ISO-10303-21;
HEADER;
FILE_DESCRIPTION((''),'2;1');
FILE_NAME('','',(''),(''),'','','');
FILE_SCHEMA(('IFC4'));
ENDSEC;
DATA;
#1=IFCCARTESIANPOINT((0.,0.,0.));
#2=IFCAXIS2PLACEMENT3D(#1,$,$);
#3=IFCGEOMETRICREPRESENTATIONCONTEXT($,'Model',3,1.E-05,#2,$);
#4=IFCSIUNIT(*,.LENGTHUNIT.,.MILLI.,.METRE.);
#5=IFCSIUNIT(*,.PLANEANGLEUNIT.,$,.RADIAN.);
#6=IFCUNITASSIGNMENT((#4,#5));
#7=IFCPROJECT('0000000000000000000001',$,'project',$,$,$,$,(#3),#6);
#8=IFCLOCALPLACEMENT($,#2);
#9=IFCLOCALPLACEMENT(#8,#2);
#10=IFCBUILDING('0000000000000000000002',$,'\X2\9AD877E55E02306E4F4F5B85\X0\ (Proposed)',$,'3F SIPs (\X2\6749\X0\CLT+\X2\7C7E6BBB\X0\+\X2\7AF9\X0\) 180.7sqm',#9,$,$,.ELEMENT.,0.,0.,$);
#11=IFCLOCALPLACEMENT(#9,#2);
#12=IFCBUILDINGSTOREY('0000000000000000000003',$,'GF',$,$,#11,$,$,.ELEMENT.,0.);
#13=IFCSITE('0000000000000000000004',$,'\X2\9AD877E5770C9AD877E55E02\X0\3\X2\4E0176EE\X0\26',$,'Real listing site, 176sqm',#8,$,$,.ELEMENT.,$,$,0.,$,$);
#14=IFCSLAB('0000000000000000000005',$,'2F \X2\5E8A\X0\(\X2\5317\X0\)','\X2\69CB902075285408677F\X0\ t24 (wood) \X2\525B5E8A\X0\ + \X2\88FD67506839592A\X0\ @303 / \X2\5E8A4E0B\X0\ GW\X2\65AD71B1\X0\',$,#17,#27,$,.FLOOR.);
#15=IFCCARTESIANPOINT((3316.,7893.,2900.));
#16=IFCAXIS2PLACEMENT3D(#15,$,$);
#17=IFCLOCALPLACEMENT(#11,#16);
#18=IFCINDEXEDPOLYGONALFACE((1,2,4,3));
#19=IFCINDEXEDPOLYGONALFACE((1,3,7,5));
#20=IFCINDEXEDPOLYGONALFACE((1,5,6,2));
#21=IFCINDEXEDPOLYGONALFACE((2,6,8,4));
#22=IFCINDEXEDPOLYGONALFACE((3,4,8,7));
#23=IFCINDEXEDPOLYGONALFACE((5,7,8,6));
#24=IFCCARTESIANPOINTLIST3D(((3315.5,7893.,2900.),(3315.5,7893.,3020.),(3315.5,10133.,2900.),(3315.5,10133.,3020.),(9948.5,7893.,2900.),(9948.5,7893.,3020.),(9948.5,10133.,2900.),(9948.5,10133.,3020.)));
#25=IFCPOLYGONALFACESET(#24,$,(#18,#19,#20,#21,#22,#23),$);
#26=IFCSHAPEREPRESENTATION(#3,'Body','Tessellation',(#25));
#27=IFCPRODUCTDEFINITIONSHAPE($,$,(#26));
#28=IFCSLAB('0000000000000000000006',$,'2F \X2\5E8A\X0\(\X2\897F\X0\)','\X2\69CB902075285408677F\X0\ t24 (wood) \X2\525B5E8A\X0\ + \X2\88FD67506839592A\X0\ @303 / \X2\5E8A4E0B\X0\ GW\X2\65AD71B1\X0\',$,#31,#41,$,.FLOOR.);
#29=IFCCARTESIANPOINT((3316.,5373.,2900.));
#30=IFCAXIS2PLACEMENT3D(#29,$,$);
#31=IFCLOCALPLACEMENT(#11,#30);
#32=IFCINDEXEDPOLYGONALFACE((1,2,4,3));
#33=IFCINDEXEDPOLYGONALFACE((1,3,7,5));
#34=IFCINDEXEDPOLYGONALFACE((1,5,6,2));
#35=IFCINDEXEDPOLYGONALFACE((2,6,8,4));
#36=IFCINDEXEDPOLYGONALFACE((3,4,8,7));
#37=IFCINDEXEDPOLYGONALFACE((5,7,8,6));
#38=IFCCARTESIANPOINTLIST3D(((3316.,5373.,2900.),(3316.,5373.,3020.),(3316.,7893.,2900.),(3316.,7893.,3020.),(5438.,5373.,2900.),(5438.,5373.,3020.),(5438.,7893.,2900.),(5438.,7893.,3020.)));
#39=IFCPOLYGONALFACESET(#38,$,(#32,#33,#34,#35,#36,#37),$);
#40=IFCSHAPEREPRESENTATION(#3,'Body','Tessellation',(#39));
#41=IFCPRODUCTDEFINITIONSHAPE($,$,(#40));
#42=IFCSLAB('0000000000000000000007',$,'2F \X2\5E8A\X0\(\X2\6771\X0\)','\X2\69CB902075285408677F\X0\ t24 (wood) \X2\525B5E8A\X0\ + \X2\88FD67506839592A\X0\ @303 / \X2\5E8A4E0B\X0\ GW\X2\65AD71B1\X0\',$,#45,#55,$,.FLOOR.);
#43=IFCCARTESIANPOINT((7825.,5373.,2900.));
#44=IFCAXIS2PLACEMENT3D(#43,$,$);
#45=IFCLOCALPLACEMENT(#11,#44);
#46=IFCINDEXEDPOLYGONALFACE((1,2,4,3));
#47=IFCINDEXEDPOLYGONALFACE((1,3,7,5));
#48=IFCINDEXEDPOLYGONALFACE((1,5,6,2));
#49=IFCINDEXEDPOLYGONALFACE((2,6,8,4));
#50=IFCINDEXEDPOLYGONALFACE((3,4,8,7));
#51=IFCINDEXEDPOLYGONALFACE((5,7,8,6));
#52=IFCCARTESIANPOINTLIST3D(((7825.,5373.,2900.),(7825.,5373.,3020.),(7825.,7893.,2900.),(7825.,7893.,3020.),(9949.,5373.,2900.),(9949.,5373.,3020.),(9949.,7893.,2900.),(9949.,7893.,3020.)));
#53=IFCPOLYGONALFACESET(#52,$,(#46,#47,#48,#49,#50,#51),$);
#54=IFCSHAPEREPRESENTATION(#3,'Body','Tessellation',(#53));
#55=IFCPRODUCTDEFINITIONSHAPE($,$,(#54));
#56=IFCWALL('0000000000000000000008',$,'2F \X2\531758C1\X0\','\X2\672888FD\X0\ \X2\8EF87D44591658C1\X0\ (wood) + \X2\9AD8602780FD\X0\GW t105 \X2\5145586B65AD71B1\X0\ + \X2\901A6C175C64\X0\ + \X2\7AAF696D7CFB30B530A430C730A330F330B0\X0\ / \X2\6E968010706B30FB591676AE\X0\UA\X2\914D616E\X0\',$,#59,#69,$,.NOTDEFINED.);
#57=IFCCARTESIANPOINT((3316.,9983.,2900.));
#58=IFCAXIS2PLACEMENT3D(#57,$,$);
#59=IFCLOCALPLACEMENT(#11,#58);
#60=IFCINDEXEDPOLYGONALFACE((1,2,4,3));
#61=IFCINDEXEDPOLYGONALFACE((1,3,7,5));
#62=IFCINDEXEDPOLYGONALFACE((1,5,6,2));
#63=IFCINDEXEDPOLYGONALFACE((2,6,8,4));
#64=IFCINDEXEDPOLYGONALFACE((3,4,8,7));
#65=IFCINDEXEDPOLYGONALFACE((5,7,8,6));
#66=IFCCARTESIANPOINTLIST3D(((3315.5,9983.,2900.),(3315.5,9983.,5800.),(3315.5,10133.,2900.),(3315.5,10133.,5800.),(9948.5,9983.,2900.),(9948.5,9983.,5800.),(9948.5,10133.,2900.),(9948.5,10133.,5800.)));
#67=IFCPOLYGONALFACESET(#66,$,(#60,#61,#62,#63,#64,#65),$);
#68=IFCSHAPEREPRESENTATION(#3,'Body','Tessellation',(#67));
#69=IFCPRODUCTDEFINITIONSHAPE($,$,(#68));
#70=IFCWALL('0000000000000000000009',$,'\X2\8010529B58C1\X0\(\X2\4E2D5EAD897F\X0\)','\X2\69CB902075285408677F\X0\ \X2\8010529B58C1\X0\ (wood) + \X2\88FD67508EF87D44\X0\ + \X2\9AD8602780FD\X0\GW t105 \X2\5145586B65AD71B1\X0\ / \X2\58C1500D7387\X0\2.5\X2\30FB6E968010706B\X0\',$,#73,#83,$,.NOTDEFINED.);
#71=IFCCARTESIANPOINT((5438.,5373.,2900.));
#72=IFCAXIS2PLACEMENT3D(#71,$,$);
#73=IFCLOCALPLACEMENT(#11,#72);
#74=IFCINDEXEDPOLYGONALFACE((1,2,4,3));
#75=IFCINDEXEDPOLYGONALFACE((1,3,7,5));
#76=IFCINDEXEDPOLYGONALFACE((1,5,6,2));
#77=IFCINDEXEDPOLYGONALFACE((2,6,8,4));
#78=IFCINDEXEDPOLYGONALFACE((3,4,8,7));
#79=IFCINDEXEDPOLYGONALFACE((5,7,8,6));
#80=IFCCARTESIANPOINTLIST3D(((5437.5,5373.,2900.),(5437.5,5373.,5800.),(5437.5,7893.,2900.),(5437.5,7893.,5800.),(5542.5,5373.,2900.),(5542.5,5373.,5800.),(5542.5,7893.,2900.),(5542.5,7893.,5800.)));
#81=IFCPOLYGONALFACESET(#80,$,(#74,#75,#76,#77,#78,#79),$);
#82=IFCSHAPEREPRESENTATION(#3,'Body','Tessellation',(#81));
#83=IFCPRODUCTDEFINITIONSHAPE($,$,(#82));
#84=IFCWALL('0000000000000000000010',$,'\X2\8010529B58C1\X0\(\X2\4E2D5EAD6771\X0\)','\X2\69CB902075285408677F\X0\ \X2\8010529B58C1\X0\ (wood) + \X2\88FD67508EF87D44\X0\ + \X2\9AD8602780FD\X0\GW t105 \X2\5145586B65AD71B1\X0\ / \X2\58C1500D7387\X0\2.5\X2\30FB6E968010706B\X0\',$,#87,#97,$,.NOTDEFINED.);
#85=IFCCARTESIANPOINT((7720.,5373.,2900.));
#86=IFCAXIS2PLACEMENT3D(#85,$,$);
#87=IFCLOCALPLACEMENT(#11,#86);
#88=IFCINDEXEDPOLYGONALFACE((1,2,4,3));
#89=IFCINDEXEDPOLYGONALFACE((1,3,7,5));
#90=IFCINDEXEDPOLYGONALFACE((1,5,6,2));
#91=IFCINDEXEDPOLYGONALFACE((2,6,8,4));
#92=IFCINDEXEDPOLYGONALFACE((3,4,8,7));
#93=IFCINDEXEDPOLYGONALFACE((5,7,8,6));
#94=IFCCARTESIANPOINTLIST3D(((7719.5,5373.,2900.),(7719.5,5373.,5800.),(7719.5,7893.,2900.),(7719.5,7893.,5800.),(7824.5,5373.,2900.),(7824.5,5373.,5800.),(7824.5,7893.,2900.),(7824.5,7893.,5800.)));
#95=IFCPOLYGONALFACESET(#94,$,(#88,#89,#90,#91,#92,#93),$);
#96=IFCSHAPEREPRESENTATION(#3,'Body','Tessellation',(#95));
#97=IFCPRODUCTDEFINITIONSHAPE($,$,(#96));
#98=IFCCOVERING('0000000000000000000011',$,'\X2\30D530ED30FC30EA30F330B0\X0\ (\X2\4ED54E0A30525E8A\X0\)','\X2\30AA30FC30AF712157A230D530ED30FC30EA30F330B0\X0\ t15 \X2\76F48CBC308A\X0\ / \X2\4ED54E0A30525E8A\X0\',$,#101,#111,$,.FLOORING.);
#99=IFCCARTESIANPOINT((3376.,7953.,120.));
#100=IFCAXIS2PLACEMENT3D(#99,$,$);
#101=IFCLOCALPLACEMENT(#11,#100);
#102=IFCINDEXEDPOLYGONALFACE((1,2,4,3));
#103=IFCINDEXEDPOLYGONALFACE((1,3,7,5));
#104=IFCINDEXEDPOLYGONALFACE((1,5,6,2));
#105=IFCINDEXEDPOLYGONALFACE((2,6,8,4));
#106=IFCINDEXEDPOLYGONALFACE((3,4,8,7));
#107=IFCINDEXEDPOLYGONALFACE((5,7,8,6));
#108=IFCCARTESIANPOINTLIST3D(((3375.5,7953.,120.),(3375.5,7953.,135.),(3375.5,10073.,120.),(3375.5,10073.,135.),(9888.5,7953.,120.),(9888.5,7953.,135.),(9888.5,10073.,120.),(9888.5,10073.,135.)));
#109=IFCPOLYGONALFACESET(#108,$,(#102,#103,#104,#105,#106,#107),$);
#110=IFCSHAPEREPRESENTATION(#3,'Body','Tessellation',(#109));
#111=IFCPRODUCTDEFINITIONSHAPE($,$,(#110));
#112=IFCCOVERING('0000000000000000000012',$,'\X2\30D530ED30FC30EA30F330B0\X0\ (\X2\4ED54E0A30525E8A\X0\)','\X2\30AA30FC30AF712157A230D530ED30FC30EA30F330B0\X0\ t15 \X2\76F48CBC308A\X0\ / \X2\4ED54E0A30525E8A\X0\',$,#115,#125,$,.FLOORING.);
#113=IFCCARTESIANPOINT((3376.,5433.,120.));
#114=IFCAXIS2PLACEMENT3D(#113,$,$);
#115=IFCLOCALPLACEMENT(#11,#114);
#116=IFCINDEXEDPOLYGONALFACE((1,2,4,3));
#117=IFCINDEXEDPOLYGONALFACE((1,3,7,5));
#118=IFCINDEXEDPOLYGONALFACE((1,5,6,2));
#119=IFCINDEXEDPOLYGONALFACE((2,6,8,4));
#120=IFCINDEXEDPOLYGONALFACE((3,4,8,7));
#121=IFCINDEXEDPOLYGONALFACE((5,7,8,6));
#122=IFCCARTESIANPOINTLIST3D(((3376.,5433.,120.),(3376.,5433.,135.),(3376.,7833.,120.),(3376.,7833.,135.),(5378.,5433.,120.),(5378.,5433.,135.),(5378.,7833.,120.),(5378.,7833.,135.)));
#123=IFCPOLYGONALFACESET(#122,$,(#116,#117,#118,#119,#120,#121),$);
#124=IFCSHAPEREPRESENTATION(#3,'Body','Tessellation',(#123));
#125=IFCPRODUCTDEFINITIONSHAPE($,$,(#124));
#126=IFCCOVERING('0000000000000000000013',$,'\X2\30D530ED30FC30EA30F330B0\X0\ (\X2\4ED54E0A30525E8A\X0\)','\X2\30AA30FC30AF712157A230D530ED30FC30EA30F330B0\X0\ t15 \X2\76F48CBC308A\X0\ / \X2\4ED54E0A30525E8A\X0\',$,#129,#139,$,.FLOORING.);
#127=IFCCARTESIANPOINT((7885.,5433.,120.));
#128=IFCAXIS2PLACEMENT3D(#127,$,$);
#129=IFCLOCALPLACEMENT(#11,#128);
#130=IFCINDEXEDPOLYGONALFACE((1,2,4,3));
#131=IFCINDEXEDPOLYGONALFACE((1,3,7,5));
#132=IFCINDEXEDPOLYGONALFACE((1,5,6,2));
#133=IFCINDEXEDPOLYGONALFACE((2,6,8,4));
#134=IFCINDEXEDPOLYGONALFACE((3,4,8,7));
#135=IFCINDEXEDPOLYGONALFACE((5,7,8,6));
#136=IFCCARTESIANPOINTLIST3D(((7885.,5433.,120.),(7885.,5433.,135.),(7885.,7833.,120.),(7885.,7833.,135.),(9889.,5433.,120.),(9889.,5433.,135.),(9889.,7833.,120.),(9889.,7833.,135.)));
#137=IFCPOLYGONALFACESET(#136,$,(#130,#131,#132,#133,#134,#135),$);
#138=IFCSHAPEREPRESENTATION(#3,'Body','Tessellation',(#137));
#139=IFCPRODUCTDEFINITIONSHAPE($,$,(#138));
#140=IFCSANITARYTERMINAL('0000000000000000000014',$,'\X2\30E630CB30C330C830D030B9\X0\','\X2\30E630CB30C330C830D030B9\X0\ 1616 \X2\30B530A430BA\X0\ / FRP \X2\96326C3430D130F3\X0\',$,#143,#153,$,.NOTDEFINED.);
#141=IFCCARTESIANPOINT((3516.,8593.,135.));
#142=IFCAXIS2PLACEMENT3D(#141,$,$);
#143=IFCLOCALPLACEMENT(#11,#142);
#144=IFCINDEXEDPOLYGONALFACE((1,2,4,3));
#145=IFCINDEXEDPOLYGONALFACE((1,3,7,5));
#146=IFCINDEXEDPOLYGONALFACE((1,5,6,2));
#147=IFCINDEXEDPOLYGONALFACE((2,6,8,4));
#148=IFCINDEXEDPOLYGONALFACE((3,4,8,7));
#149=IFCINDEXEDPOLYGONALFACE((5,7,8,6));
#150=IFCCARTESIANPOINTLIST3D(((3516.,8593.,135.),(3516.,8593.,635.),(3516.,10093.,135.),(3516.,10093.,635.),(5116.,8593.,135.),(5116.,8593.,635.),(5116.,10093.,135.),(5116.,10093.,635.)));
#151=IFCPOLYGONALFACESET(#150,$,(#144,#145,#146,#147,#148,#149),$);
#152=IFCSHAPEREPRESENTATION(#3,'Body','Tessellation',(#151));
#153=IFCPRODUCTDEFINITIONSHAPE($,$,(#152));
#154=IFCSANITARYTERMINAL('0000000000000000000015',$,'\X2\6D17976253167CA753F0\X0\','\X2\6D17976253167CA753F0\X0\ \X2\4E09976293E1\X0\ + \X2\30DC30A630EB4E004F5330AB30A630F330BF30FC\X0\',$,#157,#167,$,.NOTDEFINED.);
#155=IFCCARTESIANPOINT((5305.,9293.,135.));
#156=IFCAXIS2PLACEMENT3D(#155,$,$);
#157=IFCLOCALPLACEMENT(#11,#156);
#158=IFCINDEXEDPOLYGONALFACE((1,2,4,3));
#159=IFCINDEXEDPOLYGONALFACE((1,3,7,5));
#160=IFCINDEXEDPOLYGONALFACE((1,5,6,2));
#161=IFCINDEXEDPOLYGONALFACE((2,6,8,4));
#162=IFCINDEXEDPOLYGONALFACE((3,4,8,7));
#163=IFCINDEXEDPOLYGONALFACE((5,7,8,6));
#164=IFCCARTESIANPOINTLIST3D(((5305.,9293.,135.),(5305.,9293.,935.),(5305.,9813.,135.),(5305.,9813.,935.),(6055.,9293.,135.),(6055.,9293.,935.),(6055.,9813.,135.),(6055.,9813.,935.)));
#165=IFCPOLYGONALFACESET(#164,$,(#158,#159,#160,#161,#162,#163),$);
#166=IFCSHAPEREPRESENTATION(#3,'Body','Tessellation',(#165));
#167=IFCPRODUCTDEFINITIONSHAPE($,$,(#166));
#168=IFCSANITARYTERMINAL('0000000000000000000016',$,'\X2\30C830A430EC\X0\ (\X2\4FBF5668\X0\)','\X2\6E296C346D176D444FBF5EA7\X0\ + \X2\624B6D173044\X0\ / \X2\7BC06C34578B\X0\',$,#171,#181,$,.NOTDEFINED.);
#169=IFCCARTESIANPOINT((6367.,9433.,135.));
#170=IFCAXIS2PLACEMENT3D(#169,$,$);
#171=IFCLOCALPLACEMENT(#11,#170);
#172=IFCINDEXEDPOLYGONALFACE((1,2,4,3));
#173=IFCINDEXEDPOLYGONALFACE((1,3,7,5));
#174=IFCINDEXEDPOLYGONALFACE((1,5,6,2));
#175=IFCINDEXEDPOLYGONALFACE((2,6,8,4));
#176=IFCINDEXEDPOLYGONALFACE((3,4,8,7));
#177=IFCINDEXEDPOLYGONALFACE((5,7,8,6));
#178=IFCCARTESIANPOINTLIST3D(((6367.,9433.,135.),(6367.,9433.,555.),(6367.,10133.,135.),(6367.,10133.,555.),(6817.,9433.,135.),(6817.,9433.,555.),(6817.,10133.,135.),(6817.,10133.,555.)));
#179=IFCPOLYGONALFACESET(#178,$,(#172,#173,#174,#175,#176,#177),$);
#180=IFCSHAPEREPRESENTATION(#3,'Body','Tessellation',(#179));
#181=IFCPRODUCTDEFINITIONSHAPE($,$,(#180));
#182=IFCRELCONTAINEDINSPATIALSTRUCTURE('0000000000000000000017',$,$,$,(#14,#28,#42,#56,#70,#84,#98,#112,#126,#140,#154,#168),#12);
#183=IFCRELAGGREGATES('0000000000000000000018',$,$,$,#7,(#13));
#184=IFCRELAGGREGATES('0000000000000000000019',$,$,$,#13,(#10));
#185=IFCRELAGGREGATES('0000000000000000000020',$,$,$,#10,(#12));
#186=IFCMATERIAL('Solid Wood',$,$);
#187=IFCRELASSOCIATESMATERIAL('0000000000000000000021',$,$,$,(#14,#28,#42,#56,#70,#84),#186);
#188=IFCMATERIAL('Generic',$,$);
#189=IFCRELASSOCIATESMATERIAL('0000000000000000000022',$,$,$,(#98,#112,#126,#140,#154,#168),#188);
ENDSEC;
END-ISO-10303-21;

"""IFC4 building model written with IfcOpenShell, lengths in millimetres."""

from ifc_helpers import new_model, si_unit, frame, frame_2d, origin, place, context, project, spatial, rectangle, extrude, material, element, save


model = new_model("IFC4")

# Units and contexts
model_context = context("Model", 3, precision=1e-05, world=origin())
ifc_project = project(units=[si_unit("LENGTHUNIT", "METRE", prefix="MILLI"), si_unit("PLANEANGLEUNIT", "RADIAN")], contexts=[model_context])

# Site, building, storey
site_placement = place(None, origin())
site = spatial("IfcSite", under=ifc_project, at=site_placement, Name="高知県高知市3丁目26", ObjectType="Real listing site, 176sqm", CompositionType="ELEMENT", RefElevation=0.0)
building_placement = place(site_placement, origin())
building = spatial("IfcBuilding", under=site, at=building_placement, Name="高知市の住宅 (Proposed)", ObjectType="3F SIPs (杉CLT+籾殻+竹) 180.7sqm", CompositionType="ELEMENT", ElevationOfRefHeight=0.0, ElevationOfTerrain=0.0)
storey_placement = place(building_placement, origin())
storey = spatial("IfcBuildingStorey", under=building, at=storey_placement, Name="GF", CompositionType="ELEMENT", Elevation=0.0)

# Slabs
ifc_material_1 = material(Name="Solid Wood")
slab_1_placement = place(storey_placement, frame((3316.0, 7893.0, 2900.0)))
element("IfcSlab", 1, at=slab_1_placement, inside=storey, material=ifc_material_1, Name="2F 床(北)", Description="構造用合板 t24 (wood) 剛床 + 製材根太 @303 / 床下 GW断熱", PredefinedType="FLOOR", context=model_context, shape_type="SweptSolid", body=[
    extrude(rectangle(XDim=6633.0, YDim=2240.0, at=frame_2d((3316.0, 1120.0))), frame((3316.0, 7893.0, 2900.0)), (0.0, 0.0, 1.0), 120.0),
])
slab_2_placement = place(storey_placement, frame((3316.0, 5373.0, 2900.0)))
element("IfcSlab", 2, at=slab_2_placement, inside=storey, material=ifc_material_1, Name="2F 床(西)", Description="構造用合板 t24 (wood) 剛床 + 製材根太 @303 / 床下 GW断熱", PredefinedType="FLOOR", context=model_context, shape_type="SweptSolid", body=[
    extrude(rectangle(XDim=2122.0, YDim=2520.0, at=frame_2d((1061.0, 1260.0))), frame((3316.0, 5373.0, 2900.0)), (0.0, 0.0, 1.0), 120.0),
])
slab_3_placement = place(storey_placement, frame((7825.0, 5373.0, 2900.0)))
element("IfcSlab", 3, at=slab_3_placement, inside=storey, material=ifc_material_1, Name="2F 床(東)", Description="構造用合板 t24 (wood) 剛床 + 製材根太 @303 / 床下 GW断熱", PredefinedType="FLOOR", context=model_context, shape_type="SweptSolid", body=[
    extrude(rectangle(XDim=2124.0, YDim=2520.0, at=frame_2d((1062.0, 1260.0))), frame((7825.0, 5373.0, 2900.0)), (0.0, 0.0, 1.0), 120.0),
])

# Wall
wall_1_placement = place(storey_placement, frame((3316.0, 9983.0, 2900.0)))
element("IfcWall", 4, at=wall_1_placement, inside=storey, material=ifc_material_1, Name="2F 北壁", Description="木製 軸組外壁 (wood) + 高性能GW t105 充填断熱 + 通気層 + 窯業系サイディング / 準耐火・外皮UA配慮", PredefinedType="NOTDEFINED", context=model_context, shape_type="SweptSolid", body=[
    extrude(rectangle(XDim=6633.0, YDim=150.0, at=frame_2d((3316.0, 75.0))), frame((3316.0, 9983.0, 2900.0)), (0.0, 0.0, 1.0), 2900.0),
])

# Walls
wall_2_placement = place(storey_placement, frame((5438.0, 5373.0, 2900.0)))
element("IfcWall", 5, at=wall_2_placement, inside=storey, material=ifc_material_1, Name="耐力壁(中庭西)", Description="構造用合板 耐力壁 (wood) + 製材軸組 + 高性能GW t105 充填断熱 / 壁倍率2.5・準耐火", PredefinedType="NOTDEFINED", context=model_context, shape_type="SweptSolid", body=[
    extrude(rectangle(XDim=105.0, YDim=2520.0, at=frame_2d((52.0, 1260.0))), frame((5438.0, 5373.0, 2900.0)), (0.0, 0.0, 1.0), 2900.0),
])
wall_3_placement = place(storey_placement, frame((7720.0, 5373.0, 2900.0)))
element("IfcWall", 6, at=wall_3_placement, inside=storey, material=ifc_material_1, Name="耐力壁(中庭東)", Description="構造用合板 耐力壁 (wood) + 製材軸組 + 高性能GW t105 充填断熱 / 壁倍率2.5・準耐火", PredefinedType="NOTDEFINED", context=model_context, shape_type="SweptSolid", body=[
    extrude(rectangle(XDim=105.0, YDim=2520.0, at=frame_2d((52.0, 1260.0))), frame((7720.0, 5373.0, 2900.0)), (0.0, 0.0, 1.0), 2900.0),
])

# Coverings
ifc_material_2 = material(Name="Generic")
covering_1_placement = place(storey_placement, frame((3376.0, 7953.0, 120.0)))
element("IfcCovering", 7, at=covering_1_placement, inside=storey, material=ifc_material_2, Name="フローリング (仕上げ床)", Description="オーク無垢フローリング t15 直貼り / 仕上げ床", PredefinedType="FLOORING", context=model_context, shape_type="SweptSolid", body=[
    extrude(rectangle(XDim=6513.0, YDim=2120.0, at=frame_2d((3256.0, 1060.0))), frame((3376.0, 7953.0, 120.0)), (0.0, 0.0, 1.0), 15.0),
])
covering_2_placement = place(storey_placement, frame((3376.0, 5433.0, 120.0)))
element("IfcCovering", 8, at=covering_2_placement, inside=storey, material=ifc_material_2, Name="フローリング (仕上げ床)", Description="オーク無垢フローリング t15 直貼り / 仕上げ床", PredefinedType="FLOORING", context=model_context, shape_type="SweptSolid", body=[
    extrude(rectangle(XDim=2002.0, YDim=2400.0, at=frame_2d((1001.0, 1200.0))), frame((3376.0, 5433.0, 120.0)), (0.0, 0.0, 1.0), 15.0),
])
covering_3_placement = place(storey_placement, frame((7885.0, 5433.0, 120.0)))
element("IfcCovering", 9, at=covering_3_placement, inside=storey, material=ifc_material_2, Name="フローリング (仕上げ床)", Description="オーク無垢フローリング t15 直貼り / 仕上げ床", PredefinedType="FLOORING", context=model_context, shape_type="SweptSolid", body=[
    extrude(rectangle(XDim=2004.0, YDim=2400.0, at=frame_2d((1002.0, 1200.0))), frame((7885.0, 5433.0, 120.0)), (0.0, 0.0, 1.0), 15.0),
])

# Sanitary terminals
sanitary_terminal_1_placement = place(storey_placement, frame((3516.0, 8593.0, 135.0)))
element("IfcSanitaryTerminal", 10, at=sanitary_terminal_1_placement, inside=storey, material=ifc_material_2, Name="ユニットバス", Description="ユニットバス 1616 サイズ / FRP 防水パン", PredefinedType="NOTDEFINED", context=model_context, shape_type="SweptSolid", body=[
    extrude(rectangle(XDim=1600.0, YDim=1500.0, at=frame_2d((800.0, 750.0))), frame((3516.0, 8593.0, 135.0)), (0.0, 0.0, 1.0), 500.0),
])
sanitary_terminal_2_placement = place(storey_placement, frame((5305.0, 9293.0, 135.0)))
element("IfcSanitaryTerminal", 11, at=sanitary_terminal_2_placement, inside=storey, material=ifc_material_2, Name="洗面化粧台", Description="洗面化粧台 三面鏡 + ボウル一体カウンター", PredefinedType="NOTDEFINED", context=model_context, shape_type="SweptSolid", body=[
    extrude(rectangle(XDim=750.0, YDim=520.0, at=frame_2d((375.0, 260.0))), frame((5305.0, 9293.0, 135.0)), (0.0, 0.0, 1.0), 800.0),
])
sanitary_terminal_3_placement = place(storey_placement, frame((6367.0, 9433.0, 135.0)))
element("IfcSanitaryTerminal", 12, at=sanitary_terminal_3_placement, inside=storey, material=ifc_material_2, Name="トイレ (便器)", Description="温水洗浄便座 + 手洗い / 節水型", PredefinedType="NOTDEFINED", context=model_context, shape_type="SweptSolid", body=[
    extrude(rectangle(XDim=450.0, YDim=700.0, at=frame_2d((225.0, 350.0))), frame((6367.0, 9433.0, 135.0)), (0.0, 0.0, 1.0), 420.0),
])

save(model, "model.ifc")
